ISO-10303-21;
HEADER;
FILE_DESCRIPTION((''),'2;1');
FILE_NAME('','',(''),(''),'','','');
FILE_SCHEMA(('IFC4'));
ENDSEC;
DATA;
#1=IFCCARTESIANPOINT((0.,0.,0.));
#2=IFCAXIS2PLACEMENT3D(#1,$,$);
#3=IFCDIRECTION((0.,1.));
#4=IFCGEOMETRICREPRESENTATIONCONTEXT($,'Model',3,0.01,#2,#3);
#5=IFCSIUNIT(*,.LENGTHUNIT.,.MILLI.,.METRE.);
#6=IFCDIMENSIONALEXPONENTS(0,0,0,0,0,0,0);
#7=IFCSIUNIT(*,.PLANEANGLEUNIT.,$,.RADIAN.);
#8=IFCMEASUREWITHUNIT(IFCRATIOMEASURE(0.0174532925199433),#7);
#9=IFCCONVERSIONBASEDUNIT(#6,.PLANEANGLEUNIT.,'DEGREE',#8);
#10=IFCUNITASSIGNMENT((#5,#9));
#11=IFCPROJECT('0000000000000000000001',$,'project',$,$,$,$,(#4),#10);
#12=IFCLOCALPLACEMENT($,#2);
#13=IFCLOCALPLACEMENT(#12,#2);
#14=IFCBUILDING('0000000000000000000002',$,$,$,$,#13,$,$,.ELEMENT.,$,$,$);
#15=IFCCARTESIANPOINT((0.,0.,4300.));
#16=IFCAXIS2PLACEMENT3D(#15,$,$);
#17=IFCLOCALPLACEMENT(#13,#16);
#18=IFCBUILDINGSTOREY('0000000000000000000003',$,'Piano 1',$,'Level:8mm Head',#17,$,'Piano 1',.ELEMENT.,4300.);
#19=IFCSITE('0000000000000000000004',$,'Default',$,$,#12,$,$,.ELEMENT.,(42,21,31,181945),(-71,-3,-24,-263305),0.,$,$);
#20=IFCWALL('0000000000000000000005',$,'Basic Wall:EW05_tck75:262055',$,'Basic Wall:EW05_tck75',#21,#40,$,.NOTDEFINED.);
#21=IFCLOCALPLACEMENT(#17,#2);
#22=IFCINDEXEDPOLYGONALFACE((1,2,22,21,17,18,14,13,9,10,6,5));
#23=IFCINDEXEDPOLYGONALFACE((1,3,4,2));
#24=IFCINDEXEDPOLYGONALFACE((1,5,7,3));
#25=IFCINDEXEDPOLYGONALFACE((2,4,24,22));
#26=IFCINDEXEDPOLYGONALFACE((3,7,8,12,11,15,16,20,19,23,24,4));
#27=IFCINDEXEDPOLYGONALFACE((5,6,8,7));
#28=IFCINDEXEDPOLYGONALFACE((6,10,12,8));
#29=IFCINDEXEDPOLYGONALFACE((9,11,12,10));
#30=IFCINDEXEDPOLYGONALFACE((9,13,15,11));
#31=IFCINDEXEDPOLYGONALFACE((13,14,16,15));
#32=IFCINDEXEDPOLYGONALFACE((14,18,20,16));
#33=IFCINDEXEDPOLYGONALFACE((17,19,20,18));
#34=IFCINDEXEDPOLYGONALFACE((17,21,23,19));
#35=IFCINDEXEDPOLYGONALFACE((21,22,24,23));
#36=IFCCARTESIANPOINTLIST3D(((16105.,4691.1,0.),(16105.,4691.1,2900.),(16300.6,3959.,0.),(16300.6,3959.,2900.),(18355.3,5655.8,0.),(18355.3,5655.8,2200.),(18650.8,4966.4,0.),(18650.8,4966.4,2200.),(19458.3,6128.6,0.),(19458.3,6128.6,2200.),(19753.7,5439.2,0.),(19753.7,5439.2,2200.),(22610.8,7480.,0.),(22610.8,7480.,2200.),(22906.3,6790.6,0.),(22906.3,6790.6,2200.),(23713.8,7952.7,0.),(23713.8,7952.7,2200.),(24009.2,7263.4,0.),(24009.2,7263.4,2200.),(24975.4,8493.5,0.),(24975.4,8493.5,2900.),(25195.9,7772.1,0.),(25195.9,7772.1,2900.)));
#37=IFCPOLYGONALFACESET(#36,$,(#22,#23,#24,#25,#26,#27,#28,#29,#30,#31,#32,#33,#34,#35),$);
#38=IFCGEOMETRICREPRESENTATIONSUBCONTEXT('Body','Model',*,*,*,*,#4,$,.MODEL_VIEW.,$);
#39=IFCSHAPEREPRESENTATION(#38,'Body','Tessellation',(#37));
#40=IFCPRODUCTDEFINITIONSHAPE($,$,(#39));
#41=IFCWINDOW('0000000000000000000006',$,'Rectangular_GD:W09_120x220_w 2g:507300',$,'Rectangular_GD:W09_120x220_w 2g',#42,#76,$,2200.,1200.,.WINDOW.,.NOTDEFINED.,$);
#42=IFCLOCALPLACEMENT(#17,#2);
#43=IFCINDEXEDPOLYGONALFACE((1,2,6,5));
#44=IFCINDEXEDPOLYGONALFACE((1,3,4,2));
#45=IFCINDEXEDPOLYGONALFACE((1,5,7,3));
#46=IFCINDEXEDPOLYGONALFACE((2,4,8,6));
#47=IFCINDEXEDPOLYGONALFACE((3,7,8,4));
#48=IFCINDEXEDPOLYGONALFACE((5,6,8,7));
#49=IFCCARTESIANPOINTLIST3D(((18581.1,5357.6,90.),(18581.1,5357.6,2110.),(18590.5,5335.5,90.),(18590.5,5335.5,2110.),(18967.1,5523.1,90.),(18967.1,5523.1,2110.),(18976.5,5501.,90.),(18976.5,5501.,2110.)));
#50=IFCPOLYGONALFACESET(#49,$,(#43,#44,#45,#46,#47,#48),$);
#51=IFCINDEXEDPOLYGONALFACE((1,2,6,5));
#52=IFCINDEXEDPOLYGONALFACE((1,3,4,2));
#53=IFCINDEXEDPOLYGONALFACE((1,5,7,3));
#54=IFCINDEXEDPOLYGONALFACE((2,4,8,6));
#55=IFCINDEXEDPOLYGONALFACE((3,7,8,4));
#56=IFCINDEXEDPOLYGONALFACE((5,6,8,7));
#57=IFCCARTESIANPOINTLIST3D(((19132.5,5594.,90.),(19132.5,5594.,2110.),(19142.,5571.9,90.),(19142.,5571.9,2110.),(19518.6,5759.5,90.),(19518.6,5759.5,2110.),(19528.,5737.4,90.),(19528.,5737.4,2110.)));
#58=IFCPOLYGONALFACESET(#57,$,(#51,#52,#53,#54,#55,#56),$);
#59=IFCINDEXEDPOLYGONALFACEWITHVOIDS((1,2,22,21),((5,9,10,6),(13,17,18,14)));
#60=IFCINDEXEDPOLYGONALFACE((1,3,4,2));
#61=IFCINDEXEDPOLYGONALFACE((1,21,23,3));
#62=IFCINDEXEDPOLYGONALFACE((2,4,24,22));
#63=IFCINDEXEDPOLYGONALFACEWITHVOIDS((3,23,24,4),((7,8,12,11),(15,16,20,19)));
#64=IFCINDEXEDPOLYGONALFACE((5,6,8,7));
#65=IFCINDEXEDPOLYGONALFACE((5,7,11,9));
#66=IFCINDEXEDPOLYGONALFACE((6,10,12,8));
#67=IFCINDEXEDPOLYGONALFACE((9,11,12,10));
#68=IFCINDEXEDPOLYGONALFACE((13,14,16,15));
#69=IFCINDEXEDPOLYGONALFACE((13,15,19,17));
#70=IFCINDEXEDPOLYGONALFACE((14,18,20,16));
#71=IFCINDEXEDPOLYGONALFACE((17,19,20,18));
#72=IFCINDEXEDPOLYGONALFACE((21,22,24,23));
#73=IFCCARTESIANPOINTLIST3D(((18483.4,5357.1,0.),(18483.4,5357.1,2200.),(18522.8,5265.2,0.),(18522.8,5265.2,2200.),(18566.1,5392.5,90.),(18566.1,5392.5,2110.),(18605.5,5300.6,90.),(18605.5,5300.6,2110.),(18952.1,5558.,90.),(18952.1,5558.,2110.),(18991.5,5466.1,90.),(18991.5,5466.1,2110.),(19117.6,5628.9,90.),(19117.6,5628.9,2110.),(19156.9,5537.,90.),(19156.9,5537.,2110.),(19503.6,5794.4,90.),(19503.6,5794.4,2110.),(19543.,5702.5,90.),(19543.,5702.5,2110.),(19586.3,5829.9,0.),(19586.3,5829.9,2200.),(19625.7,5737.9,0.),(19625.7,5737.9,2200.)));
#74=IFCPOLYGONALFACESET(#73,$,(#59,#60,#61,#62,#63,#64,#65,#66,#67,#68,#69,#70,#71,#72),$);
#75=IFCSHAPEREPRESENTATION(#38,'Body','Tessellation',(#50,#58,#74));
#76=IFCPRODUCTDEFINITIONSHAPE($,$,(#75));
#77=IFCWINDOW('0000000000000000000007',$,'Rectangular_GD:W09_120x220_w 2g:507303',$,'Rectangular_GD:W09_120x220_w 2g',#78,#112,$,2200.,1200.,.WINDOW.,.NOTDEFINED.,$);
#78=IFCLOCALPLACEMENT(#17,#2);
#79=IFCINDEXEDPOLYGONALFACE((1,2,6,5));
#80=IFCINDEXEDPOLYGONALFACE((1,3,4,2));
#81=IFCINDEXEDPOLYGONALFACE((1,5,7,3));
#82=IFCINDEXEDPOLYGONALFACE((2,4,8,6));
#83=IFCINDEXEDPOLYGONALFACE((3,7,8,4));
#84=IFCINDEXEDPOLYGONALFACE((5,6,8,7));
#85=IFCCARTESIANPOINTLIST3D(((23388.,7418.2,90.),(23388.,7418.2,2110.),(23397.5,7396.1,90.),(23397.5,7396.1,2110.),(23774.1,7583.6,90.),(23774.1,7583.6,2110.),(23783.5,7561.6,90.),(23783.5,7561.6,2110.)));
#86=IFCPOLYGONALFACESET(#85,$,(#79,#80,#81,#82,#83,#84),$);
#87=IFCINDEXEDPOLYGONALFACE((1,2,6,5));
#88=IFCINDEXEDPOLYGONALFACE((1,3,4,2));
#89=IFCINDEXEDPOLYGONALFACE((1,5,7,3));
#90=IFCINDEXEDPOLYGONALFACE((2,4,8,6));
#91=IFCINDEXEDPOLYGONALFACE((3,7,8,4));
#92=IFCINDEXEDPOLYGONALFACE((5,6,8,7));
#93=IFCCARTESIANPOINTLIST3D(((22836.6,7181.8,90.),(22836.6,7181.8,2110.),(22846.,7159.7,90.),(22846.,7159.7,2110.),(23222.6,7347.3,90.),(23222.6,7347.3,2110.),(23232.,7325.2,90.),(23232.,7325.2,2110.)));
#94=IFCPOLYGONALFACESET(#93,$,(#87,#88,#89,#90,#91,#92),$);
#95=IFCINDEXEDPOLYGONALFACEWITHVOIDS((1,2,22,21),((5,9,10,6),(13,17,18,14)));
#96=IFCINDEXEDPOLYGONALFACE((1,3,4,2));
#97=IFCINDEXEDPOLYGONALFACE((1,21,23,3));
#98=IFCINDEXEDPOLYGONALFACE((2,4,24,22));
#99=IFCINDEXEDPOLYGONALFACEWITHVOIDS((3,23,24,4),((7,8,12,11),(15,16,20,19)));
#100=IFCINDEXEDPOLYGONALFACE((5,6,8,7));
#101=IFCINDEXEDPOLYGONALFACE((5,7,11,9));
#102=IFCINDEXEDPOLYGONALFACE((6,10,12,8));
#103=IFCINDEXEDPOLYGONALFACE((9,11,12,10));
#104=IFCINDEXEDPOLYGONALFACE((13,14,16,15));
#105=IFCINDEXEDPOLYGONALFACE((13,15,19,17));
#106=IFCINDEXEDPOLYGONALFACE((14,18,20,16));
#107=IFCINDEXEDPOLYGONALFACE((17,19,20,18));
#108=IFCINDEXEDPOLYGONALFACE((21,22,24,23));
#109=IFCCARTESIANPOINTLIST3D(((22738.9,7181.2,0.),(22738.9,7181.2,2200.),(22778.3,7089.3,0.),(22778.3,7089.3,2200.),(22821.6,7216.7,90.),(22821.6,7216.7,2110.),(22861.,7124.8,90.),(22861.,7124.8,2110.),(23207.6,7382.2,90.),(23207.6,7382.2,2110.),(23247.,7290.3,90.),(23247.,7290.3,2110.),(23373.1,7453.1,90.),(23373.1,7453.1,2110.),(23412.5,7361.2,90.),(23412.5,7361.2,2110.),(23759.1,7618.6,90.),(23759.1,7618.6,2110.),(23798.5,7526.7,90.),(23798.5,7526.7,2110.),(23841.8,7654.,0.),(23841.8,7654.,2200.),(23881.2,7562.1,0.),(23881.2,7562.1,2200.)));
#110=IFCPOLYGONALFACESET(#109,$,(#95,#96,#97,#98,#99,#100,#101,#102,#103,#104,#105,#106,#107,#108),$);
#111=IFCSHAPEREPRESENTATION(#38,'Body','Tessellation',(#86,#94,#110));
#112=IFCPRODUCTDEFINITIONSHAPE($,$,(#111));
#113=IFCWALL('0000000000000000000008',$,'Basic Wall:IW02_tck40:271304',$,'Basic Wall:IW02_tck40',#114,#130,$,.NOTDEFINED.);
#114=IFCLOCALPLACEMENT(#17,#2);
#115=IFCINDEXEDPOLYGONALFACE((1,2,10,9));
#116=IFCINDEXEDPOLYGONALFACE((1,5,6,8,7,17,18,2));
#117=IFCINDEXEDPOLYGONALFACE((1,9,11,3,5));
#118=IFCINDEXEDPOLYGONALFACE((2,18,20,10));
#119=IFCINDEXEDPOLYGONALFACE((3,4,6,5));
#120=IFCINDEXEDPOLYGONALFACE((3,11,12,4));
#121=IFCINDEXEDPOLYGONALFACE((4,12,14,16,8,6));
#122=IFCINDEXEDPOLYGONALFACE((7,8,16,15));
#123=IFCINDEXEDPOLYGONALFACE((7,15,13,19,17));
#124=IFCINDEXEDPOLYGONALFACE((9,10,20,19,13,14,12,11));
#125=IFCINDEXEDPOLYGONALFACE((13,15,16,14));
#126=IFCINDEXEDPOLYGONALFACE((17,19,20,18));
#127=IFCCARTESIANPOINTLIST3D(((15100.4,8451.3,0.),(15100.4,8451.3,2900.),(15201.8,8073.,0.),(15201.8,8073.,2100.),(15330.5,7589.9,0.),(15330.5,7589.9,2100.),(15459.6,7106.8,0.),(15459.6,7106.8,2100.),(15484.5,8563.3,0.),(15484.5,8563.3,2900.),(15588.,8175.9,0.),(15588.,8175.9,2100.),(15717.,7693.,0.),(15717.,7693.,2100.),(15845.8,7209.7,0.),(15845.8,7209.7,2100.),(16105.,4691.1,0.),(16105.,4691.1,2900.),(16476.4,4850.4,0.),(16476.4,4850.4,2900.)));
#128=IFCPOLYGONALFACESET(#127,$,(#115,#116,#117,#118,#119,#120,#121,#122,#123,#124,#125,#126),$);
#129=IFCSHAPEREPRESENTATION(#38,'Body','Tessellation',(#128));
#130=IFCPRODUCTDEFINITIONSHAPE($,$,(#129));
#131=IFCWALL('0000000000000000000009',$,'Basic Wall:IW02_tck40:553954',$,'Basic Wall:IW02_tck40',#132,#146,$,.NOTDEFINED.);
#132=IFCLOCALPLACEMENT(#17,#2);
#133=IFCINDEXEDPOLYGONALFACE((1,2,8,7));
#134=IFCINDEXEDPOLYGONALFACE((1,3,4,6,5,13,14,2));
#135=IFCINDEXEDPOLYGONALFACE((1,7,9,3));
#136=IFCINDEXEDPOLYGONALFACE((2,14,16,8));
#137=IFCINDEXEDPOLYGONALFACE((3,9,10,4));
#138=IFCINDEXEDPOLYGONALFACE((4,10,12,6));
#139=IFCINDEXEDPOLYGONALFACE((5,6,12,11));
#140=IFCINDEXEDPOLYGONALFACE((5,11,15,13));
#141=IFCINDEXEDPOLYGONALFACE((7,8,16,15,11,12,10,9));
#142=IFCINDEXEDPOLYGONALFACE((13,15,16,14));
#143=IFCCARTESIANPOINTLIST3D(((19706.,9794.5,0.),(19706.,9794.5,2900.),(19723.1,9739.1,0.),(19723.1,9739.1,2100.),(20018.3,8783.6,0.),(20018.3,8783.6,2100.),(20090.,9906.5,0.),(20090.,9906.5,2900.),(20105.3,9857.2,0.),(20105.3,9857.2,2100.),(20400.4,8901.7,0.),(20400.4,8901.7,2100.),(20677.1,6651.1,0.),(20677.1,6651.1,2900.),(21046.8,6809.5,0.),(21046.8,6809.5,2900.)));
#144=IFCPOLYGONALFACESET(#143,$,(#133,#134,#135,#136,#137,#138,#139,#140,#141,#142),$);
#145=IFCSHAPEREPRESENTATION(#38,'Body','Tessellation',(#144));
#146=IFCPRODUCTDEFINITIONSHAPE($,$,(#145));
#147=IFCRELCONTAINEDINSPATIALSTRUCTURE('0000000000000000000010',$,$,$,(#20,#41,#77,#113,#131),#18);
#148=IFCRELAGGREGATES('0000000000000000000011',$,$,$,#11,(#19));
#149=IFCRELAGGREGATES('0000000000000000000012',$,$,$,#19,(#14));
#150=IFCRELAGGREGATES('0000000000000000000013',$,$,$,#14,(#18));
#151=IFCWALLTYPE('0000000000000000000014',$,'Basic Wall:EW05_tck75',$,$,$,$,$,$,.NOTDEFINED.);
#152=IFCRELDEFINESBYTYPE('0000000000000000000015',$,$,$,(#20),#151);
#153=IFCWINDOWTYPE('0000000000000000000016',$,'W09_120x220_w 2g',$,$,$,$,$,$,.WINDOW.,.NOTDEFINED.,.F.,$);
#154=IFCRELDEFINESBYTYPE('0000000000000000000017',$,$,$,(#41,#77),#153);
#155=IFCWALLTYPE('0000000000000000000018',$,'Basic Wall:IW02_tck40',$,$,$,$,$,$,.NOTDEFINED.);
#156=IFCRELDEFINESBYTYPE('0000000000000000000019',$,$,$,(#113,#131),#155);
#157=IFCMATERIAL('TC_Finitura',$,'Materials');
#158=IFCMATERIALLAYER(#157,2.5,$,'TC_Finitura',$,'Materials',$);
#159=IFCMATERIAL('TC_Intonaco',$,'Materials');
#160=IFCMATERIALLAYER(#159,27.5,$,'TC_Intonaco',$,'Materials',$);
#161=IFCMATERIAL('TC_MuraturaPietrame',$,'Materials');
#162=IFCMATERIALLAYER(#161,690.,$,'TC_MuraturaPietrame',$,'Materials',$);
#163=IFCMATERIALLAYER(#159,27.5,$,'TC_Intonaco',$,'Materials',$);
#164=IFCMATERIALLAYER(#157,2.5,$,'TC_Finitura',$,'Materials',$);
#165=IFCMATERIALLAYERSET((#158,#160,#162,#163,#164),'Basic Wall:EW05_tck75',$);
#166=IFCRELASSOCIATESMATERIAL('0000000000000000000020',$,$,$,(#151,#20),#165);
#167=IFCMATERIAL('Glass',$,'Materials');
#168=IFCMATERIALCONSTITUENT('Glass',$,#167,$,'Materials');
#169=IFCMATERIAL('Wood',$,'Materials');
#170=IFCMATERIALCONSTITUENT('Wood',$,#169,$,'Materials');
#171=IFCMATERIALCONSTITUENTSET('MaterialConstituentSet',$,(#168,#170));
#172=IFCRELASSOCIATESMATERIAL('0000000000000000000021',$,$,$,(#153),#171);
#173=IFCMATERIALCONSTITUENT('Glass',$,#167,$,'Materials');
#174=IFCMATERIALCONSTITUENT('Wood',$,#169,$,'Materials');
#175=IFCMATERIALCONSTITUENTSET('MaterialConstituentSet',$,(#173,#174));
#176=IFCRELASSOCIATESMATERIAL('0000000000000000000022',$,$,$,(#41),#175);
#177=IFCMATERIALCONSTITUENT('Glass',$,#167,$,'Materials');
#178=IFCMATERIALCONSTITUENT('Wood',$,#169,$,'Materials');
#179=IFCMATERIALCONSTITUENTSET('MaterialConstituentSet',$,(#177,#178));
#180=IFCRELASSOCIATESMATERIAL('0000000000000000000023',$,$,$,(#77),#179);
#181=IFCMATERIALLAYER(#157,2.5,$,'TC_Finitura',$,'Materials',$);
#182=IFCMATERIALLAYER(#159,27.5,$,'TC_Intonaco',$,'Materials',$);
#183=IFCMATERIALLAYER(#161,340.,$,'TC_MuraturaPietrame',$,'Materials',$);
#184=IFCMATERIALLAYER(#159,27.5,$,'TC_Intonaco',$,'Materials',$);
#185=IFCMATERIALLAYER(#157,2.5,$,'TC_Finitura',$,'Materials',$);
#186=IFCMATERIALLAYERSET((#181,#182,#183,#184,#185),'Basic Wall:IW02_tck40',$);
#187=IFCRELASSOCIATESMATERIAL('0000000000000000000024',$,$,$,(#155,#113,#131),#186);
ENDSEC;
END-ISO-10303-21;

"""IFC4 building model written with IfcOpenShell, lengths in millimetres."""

from ifc_helpers import new_model, entity, si_unit, converted_unit, direction, frame, frame_2d, origin, origin_2d_with_axis, place, context, subcontext, project, spatial, polyline, rectangle, outline, extrude, clip, bounded_halfspace, source, transform, mapped, material, layer, layer_set, layer_usage, constituent, constituent_set, type_object, type_shapes, element, fill, save


model = new_model("IFC4")

# Units and contexts
model_context = context("Model", 3, precision=0.01, world=origin(), true_north=direction((0.0, 1.0)))
body_context = subcontext(model_context, "Body", "Model", "MODEL_VIEW")
ifc_project = project(units=[si_unit("LENGTHUNIT", "METRE", prefix="MILLI"), converted_unit("PLANEANGLEUNIT", "DEGREE", entity("IfcRatioMeasure", 0.0174532925199433), si_unit("PLANEANGLEUNIT", "RADIAN"), dimensions=[0, 0, 0, 0, 0, 0, 0])], contexts=[model_context])

# Site, building, storey
site_placement = place(None, origin())
site = spatial("IfcSite", under=ifc_project, at=site_placement, Name="Default", CompositionType="ELEMENT", RefLatitude=(42, 21, 31, 181945), RefLongitude=(-71, -3, -24, -263305), RefElevation=0.0)
building_placement = place(site_placement, origin())
building = spatial("IfcBuilding", under=site, at=building_placement, CompositionType="ELEMENT")
storey_placement = place(building_placement, frame((0.0, 0.0, 4300.0)))
storey = spatial("IfcBuildingStorey", under=building, at=storey_placement, Name="Piano 1", ObjectType="Level:8mm Head", LongName="Piano 1", CompositionType="ELEMENT", Elevation=4300.0)

# Shared definitions
ifc_material_1 = material(Name="TC_Finitura", Category="Materials")
ifc_material_2 = material(Name="TC_Intonaco", Category="Materials")
ifc_material_3 = material(Name="TC_MuraturaPietrame", Category="Materials")
ifc_material_4 = material(Name="Glass", Category="Materials")

# Wall, openings, windows
ifc_layer_1 = layer(ifc_material_1, 2.5, Name="TC_Finitura", Category="Materials")
ifc_layer_2 = layer(ifc_material_2, 27.5, Name="TC_Intonaco", Category="Materials")
ifc_layer_3 = layer(ifc_material_3, 690.0, Name="TC_MuraturaPietrame", Category="Materials")
ifc_layer_4 = layer(ifc_material_2, 27.5, Name="TC_Intonaco", Category="Materials")
ifc_layer_5 = layer(ifc_material_1, 2.5, Name="TC_Finitura", Category="Materials")
ifc_layer_set_1 = layer_set([ifc_layer_1, ifc_layer_2, ifc_layer_3, ifc_layer_4, ifc_layer_5], Name="Basic Wall:EW05_tck75")
ifc_layer_usage_1 = layer_usage(ifc_layer_set_1, "AXIS2", "NEGATIVE", 375.0)
wall_type_1 = type_object("IfcWallType", Name="Basic Wall:EW05_tck75", PredefinedType="NOTDEFINED", material=ifc_layer_set_1)
wall_1_placement = place(storey_placement, frame((16152.8, 4303.6, 0.0), z_axis=(0.0, 0.0, 1.0), x_axis=(0.919114, 0.393991, 0.0)))
wall_1 = element("IfcWall", 1, at=wall_1_placement, inside=storey, type_object=wall_type_1, material=ifc_layer_usage_1, Name="Basic Wall:EW05_tck75:262055", ObjectType="Basic Wall:EW05_tck75", PredefinedType="NOTDEFINED", context=body_context, shape_type="Clipping", body=[
    clip(extrude(outline(polyline([(149.6, -375.0), (9678.2, -375.0), (9759.7, 375.0), (5485.4, 375.0), (5083.2, 375.0), (512.9, 375.0), (108.7, 375.0), (3.5, -351.0), (0.0, -375.0), (149.6, -375.0)])), origin(), (0.0, 0.0, 1.0), 2900.0), bounded_halfspace(frame((149.6, -375.0, 2900.0), z_axis=(0.0, 0.0, -1.0), x_axis=(0.991461, -0.130406, 0.0)), True, frame((149.6, -375.0, 2900.0)), polyline([(0.0, 0.0), (9528.6, 0.0), (9610.2, 750.0), (5335.9, 750.0), (4933.7, 750.0), (363.3, 750.0), (-40.9, 750.0), (-146.1, 24.0), (-149.6, 0.0), (0.0, 0.0)]))),
])
opening_1_placement = place(wall_1_placement, frame((2557.1, -375.0, 0.0)))
opening_1 = element("IfcOpeningElement", 2, at=opening_1_placement, cuts=wall_1, ObjectType="Opening", PredefinedType="OPENING", context=body_context, shape_type="SweptSolid", body=[
    extrude(rectangle(XDim=2200.0, YDim=1200.0, at=frame_2d((1100.0, 600.0), x_axis=(-1.0, 0.0))), frame((0.0, 0.0, 0.0), z_axis=(0.0, 1.0, 0.0), x_axis=(0.0, 0.0, 1.0)), (0.0, 0.0, 1.0), 750.0),
])
opening_2_placement = place(wall_1_placement, frame((8387.1, 375.0, 0.0)))
opening_2 = element("IfcOpeningElement", 3, at=opening_2_placement, cuts=wall_1, ObjectType="Opening", PredefinedType="OPENING", context=body_context, shape_type="SweptSolid", body=[
    extrude(rectangle(XDim=2200.0, YDim=1200.0, at=frame_2d((1100.0, 600.0), x_axis=(-1.0, 0.0))), frame((0.0, 0.0, 0.0), z_axis=(0.0, -1.0, 0.0), x_axis=(0.0, 0.0, 1.0)), (0.0, 0.0, 1.0), 750.0),
])
ifc_constituent_1 = constituent(ifc_material_4, Name="Glass", Category="Materials")
ifc_material_5 = material(Name="Wood", Category="Materials")
ifc_constituent_2 = constituent(ifc_material_5, Name="Wood", Category="Materials")
ifc_constituent_set_1 = constituent_set(constituents=[ifc_constituent_1, ifc_constituent_2], Name="MaterialConstituentSet")
ifc_constituent_3 = constituent(ifc_material_4, Name="Glass", Category="Materials")
ifc_constituent_4 = constituent(ifc_material_5, Name="Wood", Category="Materials")
ifc_constituent_set_2 = constituent_set(constituents=[ifc_constituent_3, ifc_constituent_4], Name="MaterialConstituentSet")
window_type_1 = type_object("IfcWindowType", Name="W09_120x220_w 2g", ParameterTakesPrecedence=False, PartitioningType="NOTDEFINED", PredefinedType="WINDOW", material=ifc_constituent_set_2)
shared_shape_1 = source(origin(), body_context, "Body", "SweptSolid", [
    extrude(rectangle(XDim=24.0, YDim=420.0, at=frame_2d((0.0, 0.0), x_axis=(1.0, 0.0))), frame((300.0, 375.0, 90.0), z_axis=(0.0, 0.0, 1.0), x_axis=(0.0, 1.0, 0.0)), (0.0, 0.0, 1.0), 2020.0),
    extrude(rectangle(XDim=24.0, YDim=420.0, at=origin_2d_with_axis()), frame((900.0, 375.0, 90.0), z_axis=(0.0, 0.0, 1.0), x_axis=(0.0, 1.0, 0.0)), (0.0, 0.0, 1.0), 2020.0),
    extrude(outline(polyline([(-600.0, -1100.0), (600.0, -1100.0), (600.0, 1100.0), (-600.0, 1100.0), (-600.0, -1100.0)]), holes=[polyline([(-510.0, 1010.0), (-90.0, 1010.0), (-90.0, -1010.0), (-510.0, -1010.0), (-510.0, 1010.0)]), polyline([(90.0, -1010.0), (90.0, 1010.0), (510.0, 1010.0), (510.0, -1010.0), (90.0, -1010.0)])]), frame((600.0, 325.0, 1100.0), z_axis=(0.0, 1.0, 0.0), x_axis=(1.0, 0.0, 0.0)), (0.0, 0.0, 1.0), 100.0),
])
type_shapes(window_type_1, [shared_shape_1])
window_1_placement = place(opening_1_placement, origin())
window_1 = element("IfcWindow", 4, at=window_1_placement, inside=storey, type_object=window_type_1, material=ifc_constituent_set_1, Name="Rectangular_GD:W09_120x220_w 2g:507300", ObjectType="Rectangular_GD:W09_120x220_w 2g", OverallHeight=2200.0, OverallWidth=1200.0, PartitioningType="NOTDEFINED", PredefinedType="WINDOW", context=body_context, shape_type="MappedRepresentation", body=[
    mapped(shared_shape_1, transform((0.0, 0.0, 0.0), scale=1.0)),
])
fill(opening_1, window_1)
ifc_constituent_5 = constituent(ifc_material_4, Name="Glass", Category="Materials")
ifc_constituent_6 = constituent(ifc_material_5, Name="Wood", Category="Materials")
ifc_constituent_set_3 = constituent_set(constituents=[ifc_constituent_5, ifc_constituent_6], Name="MaterialConstituentSet")
window_2_placement = place(opening_2_placement, frame((0.0, 0.0, 0.0), z_axis=(0.0, 0.0, 1.0), x_axis=(-1.0, 0.0, 0.0)))
window_2 = element("IfcWindow", 5, at=window_2_placement, inside=storey, type_object=window_type_1, material=ifc_constituent_set_3, Name="Rectangular_GD:W09_120x220_w 2g:507303", ObjectType="Rectangular_GD:W09_120x220_w 2g", OverallHeight=2200.0, OverallWidth=1200.0, PartitioningType="NOTDEFINED", PredefinedType="WINDOW", context=body_context, shape_type="MappedRepresentation", body=[
    mapped(shared_shape_1, transform((0.0, 0.0, 0.0), scale=1.0)),
])
fill(opening_2, window_2)

# Walls, openings
ifc_layer_6 = layer(ifc_material_1, 2.5, Name="TC_Finitura", Category="Materials")
ifc_layer_7 = layer(ifc_material_2, 27.5, Name="TC_Intonaco", Category="Materials")
ifc_layer_8 = layer(ifc_material_3, 340.0, Name="TC_MuraturaPietrame", Category="Materials")
ifc_layer_9 = layer(ifc_material_2, 27.5, Name="TC_Intonaco", Category="Materials")
ifc_layer_10 = layer(ifc_material_1, 2.5, Name="TC_Finitura", Category="Materials")
ifc_layer_set_2 = layer_set([ifc_layer_6, ifc_layer_7, ifc_layer_8, ifc_layer_9, ifc_layer_10], Name="Basic Wall:IW02_tck40")
ifc_layer_usage_2 = layer_usage(ifc_layer_set_2, "AXIS2", "NEGATIVE", 200.0)
wall_type_2 = type_object("IfcWallType", Name="Basic Wall:IW02_tck40", PredefinedType="NOTDEFINED", material=ifc_layer_set_2)
wall_2_placement = place(storey_placement, frame((16298.2, 4742.8, 0.0), z_axis=(0.0, 0.0, 1.0), x_axis=(-0.258104, 0.966117, 0.0)))
wall_2 = element("IfcWall", 6, at=wall_2_placement, inside=storey, type_object=wall_type_2, material=ifc_layer_usage_2, Name="Basic Wall:IW02_tck40:271304", ObjectType="Basic Wall:IW02_tck40", PredefinedType="NOTDEFINED", context=body_context, shape_type="Clipping", body=[
    clip(extrude(outline(polyline([(58.0, -200.0), (3901.1, -200.0), (3892.0, 200.0), (2496.5, 200.0), (2346.5, 200.0), (66.6, 200.0), (0.0, 200.0), (58.0, -200.0)])), origin(), (0.0, 0.0, 1.0), 2900.0), bounded_halfspace(frame((58.0, -200.0, 2900.0), z_axis=(0.0, 0.0, -1.0), x_axis=(0.013131, -0.999914, 0.0)), True, frame((58.0, -200.0, 2900.0)), polyline([(0.0, 0.0), (3843.2, 0.0), (3834.1, 400.0), (2438.5, 400.0), (2288.5, 400.0), (8.6, 400.0), (-58.0, 400.0), (0.0, 0.0)]))),
])
opening_3_placement = place(wall_2_placement, frame((3500.4, 199.6, 0.0)))
element("IfcOpeningElement", 7, at=opening_3_placement, cuts=wall_2, ObjectType="Opening", PredefinedType="OPENING", context=body_context, shape_type="SweptSolid", body=[
    extrude(rectangle(XDim=2100.0, YDim=1000.0, at=frame_2d((1050.0, 500.0), x_axis=(1.0, 0.0))), frame((0.0, 0.0, 0.0), z_axis=(-0.00074, -1.0, 0.0), x_axis=(0.0, 0.0, 1.0)), (0.0, 0.0, 1.0), 400.0),
])
ifc_layer_usage_3 = layer_usage(ifc_layer_set_2, "AXIS2", "NEGATIVE", 200.0)
wall_3_placement = place(storey_placement, frame((19897.1, 9853.5, 0.0), z_axis=(0.0, 0.0, 1.0), x_axis=(0.295178, -0.955442, 0.0)))
wall_3 = element("IfcWall", 8, at=wall_3_placement, inside=storey, type_object=wall_type_2, material=ifc_layer_usage_3, Name="Basic Wall:IW02_tck40:553954", ObjectType="Basic Wall:IW02_tck40", PredefinedType="NOTDEFINED", context=body_context, shape_type="Clipping", body=[
    clip(extrude(outline(polyline([(0.0, -200.0), (3290.0, -200.0), (3247.7, 200.0), (1379.9, 200.0), (1229.3, 200.0), (6.4, 200.0), (0.0, -200.0)])), origin(), (0.0, 0.0, 1.0), 2900.0), bounded_halfspace(frame((0.0, -200.0, 2900.0), z_axis=(0.0, 0.0, -1.0), x_axis=(0.025449, 0.999676, 0.0)), True, frame((0.0, -200.0, 2900.0)), polyline([(0.0, 0.0), (3290.0, 0.0), (3247.7, 400.0), (1379.9, 400.0), (1229.3, 400.0), (6.4, 400.0), (0.0, 0.0)]))),
])
opening_4_placement = place(wall_3_placement, frame((58.0, -200.0, 0.0)))
element("IfcOpeningElement", 9, at=opening_4_placement, cuts=wall_3, ObjectType="Opening", PredefinedType="OPENING", context=body_context, shape_type="SweptSolid", body=[
    extrude(rectangle(XDim=2100.0, YDim=1000.0, at=frame_2d((1050.0, 500.0), x_axis=(1.0, 0.0))), frame((0.0, 0.0, 0.0), z_axis=(0.0, 1.0, 0.0), x_axis=(0.0, 0.0, 1.0)), (0.0, 0.0, 1.0), 400.0),
])

save(model, "model.ifc")
